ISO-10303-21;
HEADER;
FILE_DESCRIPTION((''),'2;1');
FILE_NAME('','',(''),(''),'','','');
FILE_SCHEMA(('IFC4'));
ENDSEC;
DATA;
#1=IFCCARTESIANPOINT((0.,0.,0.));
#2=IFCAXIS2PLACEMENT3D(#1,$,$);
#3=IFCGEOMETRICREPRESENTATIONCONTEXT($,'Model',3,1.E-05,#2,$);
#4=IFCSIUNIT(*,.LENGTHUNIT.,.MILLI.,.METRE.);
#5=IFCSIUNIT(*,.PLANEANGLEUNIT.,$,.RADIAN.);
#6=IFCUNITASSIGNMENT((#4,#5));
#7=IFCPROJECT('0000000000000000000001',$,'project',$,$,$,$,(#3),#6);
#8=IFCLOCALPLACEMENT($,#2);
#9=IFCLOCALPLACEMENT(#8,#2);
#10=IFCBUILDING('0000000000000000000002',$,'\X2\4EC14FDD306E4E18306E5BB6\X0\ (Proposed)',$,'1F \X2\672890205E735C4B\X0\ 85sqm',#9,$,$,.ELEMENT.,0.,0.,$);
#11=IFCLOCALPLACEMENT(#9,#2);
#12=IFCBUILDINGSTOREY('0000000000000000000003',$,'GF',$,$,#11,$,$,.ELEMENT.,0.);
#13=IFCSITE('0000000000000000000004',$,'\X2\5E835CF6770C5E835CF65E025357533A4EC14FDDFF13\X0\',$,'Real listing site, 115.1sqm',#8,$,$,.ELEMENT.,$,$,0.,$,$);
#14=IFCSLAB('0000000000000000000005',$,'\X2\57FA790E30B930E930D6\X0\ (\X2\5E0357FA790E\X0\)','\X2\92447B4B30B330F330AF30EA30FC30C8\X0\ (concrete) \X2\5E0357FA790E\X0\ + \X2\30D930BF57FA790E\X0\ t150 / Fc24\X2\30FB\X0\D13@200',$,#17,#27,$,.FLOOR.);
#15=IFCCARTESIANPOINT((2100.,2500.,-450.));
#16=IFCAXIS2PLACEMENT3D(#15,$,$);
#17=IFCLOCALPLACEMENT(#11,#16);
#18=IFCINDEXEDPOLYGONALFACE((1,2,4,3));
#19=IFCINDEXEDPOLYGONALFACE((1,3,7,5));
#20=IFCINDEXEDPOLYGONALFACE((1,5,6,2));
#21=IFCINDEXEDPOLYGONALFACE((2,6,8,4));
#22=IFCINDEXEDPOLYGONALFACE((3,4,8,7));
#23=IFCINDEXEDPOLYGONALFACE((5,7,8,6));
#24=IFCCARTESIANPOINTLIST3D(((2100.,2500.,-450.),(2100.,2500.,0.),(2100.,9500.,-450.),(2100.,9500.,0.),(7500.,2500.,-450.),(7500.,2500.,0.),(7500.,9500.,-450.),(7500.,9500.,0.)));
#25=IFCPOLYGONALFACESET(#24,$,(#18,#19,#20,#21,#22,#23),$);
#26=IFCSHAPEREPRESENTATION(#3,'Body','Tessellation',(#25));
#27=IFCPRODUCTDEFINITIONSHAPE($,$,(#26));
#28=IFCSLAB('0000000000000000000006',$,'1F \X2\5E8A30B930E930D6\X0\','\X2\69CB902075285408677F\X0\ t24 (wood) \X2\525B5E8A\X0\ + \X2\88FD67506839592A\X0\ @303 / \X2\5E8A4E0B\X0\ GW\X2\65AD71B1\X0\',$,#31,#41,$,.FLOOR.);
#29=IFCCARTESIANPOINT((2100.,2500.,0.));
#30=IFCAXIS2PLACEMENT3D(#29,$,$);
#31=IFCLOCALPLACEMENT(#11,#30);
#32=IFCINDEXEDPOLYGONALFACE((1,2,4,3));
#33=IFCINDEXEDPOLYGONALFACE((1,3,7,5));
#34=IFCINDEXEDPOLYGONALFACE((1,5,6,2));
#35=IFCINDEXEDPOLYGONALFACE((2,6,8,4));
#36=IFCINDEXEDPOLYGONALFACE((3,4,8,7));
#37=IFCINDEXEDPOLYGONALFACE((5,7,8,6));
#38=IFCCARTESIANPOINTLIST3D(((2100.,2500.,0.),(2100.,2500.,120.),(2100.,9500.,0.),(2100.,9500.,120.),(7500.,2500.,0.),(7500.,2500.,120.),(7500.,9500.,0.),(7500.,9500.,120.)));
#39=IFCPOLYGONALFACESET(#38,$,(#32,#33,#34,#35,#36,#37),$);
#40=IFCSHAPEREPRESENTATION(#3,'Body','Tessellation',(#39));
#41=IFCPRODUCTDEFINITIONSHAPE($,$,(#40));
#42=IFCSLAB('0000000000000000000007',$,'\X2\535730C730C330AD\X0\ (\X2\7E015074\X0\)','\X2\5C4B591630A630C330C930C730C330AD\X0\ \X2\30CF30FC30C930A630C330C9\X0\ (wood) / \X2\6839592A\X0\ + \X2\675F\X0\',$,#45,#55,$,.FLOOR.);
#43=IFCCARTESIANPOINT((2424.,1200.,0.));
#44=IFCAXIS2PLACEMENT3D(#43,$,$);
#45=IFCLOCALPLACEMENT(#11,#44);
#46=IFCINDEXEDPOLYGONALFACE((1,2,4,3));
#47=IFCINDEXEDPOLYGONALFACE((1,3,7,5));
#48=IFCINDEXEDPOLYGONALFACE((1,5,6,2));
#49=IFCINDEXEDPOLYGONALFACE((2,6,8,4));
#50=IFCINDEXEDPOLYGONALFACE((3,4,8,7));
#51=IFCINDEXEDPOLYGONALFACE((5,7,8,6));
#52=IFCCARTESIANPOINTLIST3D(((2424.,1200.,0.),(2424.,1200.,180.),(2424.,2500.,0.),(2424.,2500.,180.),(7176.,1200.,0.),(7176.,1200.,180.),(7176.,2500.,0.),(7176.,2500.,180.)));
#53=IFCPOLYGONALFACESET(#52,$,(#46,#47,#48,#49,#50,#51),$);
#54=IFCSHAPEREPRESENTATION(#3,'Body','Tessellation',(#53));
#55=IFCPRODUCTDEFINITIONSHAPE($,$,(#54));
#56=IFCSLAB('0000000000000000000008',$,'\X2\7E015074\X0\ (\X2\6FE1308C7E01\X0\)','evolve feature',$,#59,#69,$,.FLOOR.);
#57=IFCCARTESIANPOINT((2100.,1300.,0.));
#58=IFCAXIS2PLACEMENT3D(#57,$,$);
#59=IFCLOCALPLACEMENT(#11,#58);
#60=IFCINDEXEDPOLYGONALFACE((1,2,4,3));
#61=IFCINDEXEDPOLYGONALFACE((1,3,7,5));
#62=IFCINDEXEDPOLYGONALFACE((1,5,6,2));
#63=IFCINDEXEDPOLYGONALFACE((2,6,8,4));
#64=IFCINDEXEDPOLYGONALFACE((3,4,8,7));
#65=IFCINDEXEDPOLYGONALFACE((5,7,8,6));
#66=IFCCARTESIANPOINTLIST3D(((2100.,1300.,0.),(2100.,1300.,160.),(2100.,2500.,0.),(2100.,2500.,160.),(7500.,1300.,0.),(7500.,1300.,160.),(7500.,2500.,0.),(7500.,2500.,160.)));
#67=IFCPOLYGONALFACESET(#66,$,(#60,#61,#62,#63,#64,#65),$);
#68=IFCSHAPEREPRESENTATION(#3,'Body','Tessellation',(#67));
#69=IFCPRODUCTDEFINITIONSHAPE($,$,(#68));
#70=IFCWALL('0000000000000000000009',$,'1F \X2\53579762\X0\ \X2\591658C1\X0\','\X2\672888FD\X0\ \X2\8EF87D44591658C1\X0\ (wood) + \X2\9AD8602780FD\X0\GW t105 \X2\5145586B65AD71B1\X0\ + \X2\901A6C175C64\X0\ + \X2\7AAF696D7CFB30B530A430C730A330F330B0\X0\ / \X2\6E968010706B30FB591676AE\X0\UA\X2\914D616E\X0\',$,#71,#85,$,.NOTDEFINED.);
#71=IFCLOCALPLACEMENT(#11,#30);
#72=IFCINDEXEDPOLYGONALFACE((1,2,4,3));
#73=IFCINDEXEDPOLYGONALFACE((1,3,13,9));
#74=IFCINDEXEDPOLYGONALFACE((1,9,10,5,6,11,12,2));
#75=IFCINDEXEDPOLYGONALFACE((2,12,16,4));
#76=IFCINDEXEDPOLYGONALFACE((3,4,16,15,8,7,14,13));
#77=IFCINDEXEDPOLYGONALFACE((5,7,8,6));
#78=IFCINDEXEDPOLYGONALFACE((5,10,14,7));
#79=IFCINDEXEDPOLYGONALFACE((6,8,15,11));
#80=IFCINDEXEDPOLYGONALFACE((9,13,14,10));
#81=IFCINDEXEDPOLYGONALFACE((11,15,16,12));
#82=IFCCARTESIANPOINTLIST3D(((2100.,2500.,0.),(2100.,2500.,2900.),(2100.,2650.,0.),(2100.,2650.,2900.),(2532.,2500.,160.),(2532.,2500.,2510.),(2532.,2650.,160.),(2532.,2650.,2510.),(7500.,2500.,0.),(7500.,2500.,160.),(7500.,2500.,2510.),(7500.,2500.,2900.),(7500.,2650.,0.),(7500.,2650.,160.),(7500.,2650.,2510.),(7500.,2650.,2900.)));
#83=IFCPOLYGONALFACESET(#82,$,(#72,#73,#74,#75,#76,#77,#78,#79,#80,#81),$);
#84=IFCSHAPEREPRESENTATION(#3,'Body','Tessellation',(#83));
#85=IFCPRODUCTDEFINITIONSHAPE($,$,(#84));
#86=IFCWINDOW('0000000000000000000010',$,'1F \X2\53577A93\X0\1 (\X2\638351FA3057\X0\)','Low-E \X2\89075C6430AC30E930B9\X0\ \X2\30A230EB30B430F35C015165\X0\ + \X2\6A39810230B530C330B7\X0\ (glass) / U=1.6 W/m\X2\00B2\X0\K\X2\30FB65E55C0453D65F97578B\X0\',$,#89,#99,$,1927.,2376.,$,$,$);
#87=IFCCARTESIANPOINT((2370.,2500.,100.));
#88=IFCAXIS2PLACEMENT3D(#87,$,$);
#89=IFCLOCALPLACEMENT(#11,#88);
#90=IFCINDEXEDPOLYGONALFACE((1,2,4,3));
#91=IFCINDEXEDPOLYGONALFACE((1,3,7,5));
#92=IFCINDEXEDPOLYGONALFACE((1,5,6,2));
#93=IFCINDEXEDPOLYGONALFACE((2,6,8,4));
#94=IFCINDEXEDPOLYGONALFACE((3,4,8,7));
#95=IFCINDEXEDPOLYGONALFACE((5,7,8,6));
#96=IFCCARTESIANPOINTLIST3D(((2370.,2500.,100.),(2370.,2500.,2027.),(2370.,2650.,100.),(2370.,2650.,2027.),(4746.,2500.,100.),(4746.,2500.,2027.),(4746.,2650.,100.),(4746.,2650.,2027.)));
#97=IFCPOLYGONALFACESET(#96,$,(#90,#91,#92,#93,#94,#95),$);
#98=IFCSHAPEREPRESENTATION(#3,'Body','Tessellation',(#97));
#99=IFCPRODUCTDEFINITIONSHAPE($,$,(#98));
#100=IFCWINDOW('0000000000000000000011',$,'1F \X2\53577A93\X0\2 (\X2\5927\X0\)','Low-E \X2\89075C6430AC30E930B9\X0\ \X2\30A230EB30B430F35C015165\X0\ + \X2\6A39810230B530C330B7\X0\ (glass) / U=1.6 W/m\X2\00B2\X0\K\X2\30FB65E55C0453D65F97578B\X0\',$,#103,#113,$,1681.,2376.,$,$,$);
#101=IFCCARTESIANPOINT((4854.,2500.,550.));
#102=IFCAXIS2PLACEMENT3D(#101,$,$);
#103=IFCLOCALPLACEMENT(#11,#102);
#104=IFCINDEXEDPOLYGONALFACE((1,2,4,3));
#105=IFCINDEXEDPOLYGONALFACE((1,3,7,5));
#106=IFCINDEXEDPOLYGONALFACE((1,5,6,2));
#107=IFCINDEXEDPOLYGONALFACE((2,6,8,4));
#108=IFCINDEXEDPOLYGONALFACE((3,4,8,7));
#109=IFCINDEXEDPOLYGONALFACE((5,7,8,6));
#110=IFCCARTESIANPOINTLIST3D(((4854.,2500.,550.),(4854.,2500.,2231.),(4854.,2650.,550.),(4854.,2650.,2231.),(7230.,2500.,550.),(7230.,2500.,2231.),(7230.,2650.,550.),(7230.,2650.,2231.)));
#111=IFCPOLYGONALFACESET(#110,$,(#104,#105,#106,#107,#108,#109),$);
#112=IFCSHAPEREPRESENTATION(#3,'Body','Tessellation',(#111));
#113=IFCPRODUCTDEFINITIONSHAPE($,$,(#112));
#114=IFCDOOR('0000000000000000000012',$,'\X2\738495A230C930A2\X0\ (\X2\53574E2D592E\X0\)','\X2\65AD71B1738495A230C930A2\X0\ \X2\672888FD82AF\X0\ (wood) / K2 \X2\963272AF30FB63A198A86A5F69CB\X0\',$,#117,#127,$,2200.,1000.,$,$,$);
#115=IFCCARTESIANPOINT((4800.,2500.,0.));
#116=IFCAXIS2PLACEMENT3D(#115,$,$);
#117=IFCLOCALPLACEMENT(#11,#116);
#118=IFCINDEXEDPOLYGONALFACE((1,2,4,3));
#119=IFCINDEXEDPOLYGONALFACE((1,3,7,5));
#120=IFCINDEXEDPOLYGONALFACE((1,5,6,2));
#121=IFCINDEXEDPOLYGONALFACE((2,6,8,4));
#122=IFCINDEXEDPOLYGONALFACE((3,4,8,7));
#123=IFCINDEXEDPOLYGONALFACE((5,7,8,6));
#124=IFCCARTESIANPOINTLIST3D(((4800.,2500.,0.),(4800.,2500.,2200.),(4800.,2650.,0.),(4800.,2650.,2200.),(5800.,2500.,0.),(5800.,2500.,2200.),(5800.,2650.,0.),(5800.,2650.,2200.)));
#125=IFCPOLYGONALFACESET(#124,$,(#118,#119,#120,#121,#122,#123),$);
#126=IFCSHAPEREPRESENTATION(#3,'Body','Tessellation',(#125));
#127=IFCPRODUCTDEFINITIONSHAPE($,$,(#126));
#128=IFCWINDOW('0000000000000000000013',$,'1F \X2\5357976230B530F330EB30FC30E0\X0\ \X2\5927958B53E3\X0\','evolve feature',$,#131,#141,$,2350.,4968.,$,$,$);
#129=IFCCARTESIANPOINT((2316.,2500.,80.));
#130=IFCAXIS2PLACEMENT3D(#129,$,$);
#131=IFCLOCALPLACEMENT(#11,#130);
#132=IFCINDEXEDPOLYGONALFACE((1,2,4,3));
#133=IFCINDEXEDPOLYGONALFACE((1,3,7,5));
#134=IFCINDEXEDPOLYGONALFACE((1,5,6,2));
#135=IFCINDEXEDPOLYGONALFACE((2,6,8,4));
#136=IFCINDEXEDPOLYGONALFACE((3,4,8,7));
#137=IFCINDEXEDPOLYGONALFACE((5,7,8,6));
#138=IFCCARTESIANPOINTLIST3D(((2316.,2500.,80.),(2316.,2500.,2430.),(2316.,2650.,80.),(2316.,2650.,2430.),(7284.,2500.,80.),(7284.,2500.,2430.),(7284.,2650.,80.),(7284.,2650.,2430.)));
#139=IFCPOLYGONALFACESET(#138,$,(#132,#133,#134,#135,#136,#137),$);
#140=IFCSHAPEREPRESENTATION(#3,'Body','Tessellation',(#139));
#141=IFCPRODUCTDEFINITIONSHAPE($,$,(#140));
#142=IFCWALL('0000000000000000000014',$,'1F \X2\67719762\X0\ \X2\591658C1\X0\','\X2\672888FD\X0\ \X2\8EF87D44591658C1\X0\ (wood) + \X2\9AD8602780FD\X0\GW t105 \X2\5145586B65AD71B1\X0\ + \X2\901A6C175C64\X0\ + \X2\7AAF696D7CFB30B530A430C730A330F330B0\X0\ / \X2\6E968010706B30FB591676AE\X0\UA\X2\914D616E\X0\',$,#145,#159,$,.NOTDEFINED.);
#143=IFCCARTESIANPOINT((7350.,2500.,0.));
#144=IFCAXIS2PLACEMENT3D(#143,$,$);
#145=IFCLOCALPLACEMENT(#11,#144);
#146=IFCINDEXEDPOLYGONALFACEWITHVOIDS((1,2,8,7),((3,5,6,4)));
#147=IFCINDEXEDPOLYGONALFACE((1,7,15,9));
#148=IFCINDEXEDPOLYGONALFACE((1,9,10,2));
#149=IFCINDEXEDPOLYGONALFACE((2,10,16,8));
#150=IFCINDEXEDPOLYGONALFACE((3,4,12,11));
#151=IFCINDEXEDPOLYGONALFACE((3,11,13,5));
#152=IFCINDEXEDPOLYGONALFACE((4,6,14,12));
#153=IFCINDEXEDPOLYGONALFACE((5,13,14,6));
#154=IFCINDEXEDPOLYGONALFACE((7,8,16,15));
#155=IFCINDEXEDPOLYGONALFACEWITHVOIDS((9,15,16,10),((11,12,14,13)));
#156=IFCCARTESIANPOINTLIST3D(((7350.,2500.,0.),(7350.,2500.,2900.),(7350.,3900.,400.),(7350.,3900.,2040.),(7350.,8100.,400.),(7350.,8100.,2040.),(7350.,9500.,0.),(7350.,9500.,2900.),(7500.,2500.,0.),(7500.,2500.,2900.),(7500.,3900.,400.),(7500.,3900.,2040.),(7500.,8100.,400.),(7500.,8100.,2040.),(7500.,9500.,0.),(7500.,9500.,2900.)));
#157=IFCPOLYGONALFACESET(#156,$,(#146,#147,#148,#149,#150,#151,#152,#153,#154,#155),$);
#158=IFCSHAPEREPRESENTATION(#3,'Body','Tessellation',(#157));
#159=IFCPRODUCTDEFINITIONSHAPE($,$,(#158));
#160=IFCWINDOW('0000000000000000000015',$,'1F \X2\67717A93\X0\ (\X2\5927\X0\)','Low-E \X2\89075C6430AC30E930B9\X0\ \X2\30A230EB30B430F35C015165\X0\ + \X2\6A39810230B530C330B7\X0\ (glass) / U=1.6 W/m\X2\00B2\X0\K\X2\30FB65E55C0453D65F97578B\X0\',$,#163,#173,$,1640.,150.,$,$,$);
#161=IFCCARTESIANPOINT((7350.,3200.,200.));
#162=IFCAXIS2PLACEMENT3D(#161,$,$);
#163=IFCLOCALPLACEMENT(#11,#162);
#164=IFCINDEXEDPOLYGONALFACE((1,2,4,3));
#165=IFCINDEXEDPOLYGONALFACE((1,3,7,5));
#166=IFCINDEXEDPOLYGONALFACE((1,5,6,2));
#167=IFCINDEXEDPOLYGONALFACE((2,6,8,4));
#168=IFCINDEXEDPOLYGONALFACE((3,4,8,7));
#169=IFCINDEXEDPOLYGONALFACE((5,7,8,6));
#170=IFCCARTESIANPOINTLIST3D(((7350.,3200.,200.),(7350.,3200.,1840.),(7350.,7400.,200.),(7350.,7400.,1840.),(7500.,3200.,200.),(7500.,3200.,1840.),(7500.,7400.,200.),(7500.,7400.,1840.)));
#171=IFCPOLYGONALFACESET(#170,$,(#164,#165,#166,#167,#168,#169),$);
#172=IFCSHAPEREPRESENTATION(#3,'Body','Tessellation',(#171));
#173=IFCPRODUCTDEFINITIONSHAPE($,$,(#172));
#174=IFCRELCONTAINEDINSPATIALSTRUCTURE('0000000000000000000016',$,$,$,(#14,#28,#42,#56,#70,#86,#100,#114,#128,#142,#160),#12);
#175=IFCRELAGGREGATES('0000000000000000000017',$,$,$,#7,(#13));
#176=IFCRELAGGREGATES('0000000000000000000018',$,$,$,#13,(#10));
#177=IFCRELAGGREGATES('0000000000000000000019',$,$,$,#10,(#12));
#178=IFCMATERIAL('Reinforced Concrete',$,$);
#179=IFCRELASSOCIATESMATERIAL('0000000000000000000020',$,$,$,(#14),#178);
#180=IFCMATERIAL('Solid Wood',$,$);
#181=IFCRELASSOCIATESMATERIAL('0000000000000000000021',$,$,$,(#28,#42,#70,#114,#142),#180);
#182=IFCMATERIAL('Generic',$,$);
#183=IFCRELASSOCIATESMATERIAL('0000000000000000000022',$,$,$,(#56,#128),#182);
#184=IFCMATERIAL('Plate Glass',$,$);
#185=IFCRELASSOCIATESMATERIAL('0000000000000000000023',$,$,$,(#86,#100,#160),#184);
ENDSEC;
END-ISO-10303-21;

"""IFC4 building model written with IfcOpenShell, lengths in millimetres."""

from ifc_helpers import new_model, si_unit, frame, frame_2d, origin, place, context, project, spatial, rectangle, extrude, material, element, fill, save


model = new_model("IFC4")

# Units and contexts
model_context = context("Model", 3, precision=1e-05, world=origin())
ifc_project = project(units=[si_unit("LENGTHUNIT", "METRE", prefix="MILLI"), si_unit("PLANEANGLEUNIT", "RADIAN")], contexts=[model_context])

# Site, building, storey
site_placement = place(None, origin())
site = spatial("IfcSite", under=ifc_project, at=site_placement, Name="広島県広島市南区仁保３", ObjectType="Real listing site, 115.1sqm", CompositionType="ELEMENT", RefElevation=0.0)
building_placement = place(site_placement, origin())
building = spatial("IfcBuilding", under=site, at=building_placement, Name="仁保の丘の家 (Proposed)", ObjectType="1F 木造平屋 85sqm", CompositionType="ELEMENT", ElevationOfRefHeight=0.0, ElevationOfTerrain=0.0)
storey_placement = place(building_placement, origin())
storey = spatial("IfcBuildingStorey", under=building, at=storey_placement, Name="GF", CompositionType="ELEMENT", Elevation=0.0)

# Slabs
ifc_material_1 = material(Name="Reinforced Concrete")
slab_1_placement = place(storey_placement, frame((2100.0, 2500.0, -450.0)))
element("IfcSlab", 1, at=slab_1_placement, inside=storey, material=ifc_material_1, Name="基礎スラブ (布基礎)", Description="鉄筋コンクリート (concrete) 布基礎 + ベタ基礎 t150 / Fc24・D13@200", PredefinedType="FLOOR", context=model_context, shape_type="SweptSolid", body=[
    extrude(rectangle(XDim=5400.0, YDim=7000.0, at=frame_2d((2700.0, 3500.0))), frame((2100.0, 2500.0, -450.0)), (0.0, 0.0, 1.0), 450.0),
])
ifc_material_2 = material(Name="Solid Wood")
slab_2_placement = place(storey_placement, frame((2100.0, 2500.0, 0.0)))
element("IfcSlab", 2, at=slab_2_placement, inside=storey, material=ifc_material_2, Name="1F 床スラブ", Description="構造用合板 t24 (wood) 剛床 + 製材根太 @303 / 床下 GW断熱", PredefinedType="FLOOR", context=model_context, shape_type="SweptSolid", body=[
    extrude(rectangle(XDim=5400.0, YDim=7000.0, at=frame_2d((2700.0, 3500.0))), frame((2100.0, 2500.0, 0.0)), (0.0, 0.0, 1.0), 120.0),
])
slab_3_placement = place(storey_placement, frame((2424.0, 1200.0, 0.0)))
element("IfcSlab", 3, at=slab_3_placement, inside=storey, material=ifc_material_2, Name="南デッキ (縁側)", Description="屋外ウッドデッキ ハードウッド (wood) / 根太 + 束", PredefinedType="FLOOR", context=model_context, shape_type="SweptSolid", body=[
    extrude(rectangle(XDim=4752.0, YDim=1300.0, at=frame_2d((2376.0, 650.0))), frame((2424.0, 1200.0, 0.0)), (0.0, 0.0, 1.0), 180.0),
])
ifc_material_3 = material(Name="Generic")
slab_4_placement = place(storey_placement, frame((2100.0, 1300.0, 0.0)))
element("IfcSlab", 4, at=slab_4_placement, inside=storey, material=ifc_material_3, Name="縁側 (濡れ縁)", Description="evolve feature", PredefinedType="FLOOR", context=model_context, shape_type="SweptSolid", body=[
    extrude(rectangle(XDim=5400.0, YDim=1200.0, at=frame_2d((2700.0, 600.0))), frame((2100.0, 1300.0, 0.0)), (0.0, 0.0, 1.0), 160.0),
])

# Wall, openings, windows, door
wall_1_placement = place(storey_placement, frame((2100.0, 2500.0, 0.0)))
wall_1 = element("IfcWall", 5, at=wall_1_placement, inside=storey, material=ifc_material_2, Name="1F 南面 外壁", Description="木製 軸組外壁 (wood) + 高性能GW t105 充填断熱 + 通気層 + 窯業系サイディング / 準耐火・外皮UA配慮", PredefinedType="NOTDEFINED", context=model_context, shape_type="SweptSolid", body=[
    extrude(rectangle(XDim=5400.0, YDim=150.0, at=frame_2d((2700.0, 75.0))), frame((2100.0, 2500.0, 0.0)), (0.0, 0.0, 1.0), 2900.0),
])
opening_1_placement = place(storey_placement, frame((2370.0, 2500.0, 100.0)))
opening_1 = element("IfcOpeningElement", 6, at=opening_1_placement, cuts=wall_1, PredefinedType="NOTDEFINED", context=model_context, shape_type="SweptSolid", body=[
    extrude(rectangle(XDim=2376.0, YDim=150.0, at=frame_2d((1188.0, 75.0))), frame((2370.0, 2500.0, 100.0)), (0.0, 0.0, 1.0), 1927.0),
])
opening_2_placement = place(storey_placement, frame((4854.0, 2500.0, 550.0)))
opening_2 = element("IfcOpeningElement", 7, at=opening_2_placement, cuts=wall_1, PredefinedType="NOTDEFINED", context=model_context, shape_type="SweptSolid", body=[
    extrude(rectangle(XDim=2376.0, YDim=150.0, at=frame_2d((1188.0, 75.0))), frame((4854.0, 2500.0, 550.0)), (0.0, 0.0, 1.0), 1681.0),
])
opening_3_placement = place(storey_placement, frame((4800.0, 2500.0, 0.0)))
opening_3 = element("IfcOpeningElement", 8, at=opening_3_placement, cuts=wall_1, PredefinedType="NOTDEFINED", context=model_context, shape_type="SweptSolid", body=[
    extrude(rectangle(XDim=1000.0, YDim=150.0, at=frame_2d((500.0, 75.0))), frame((4800.0, 2500.0, 0.0)), (0.0, 0.0, 1.0), 2200.0),
])
opening_4_placement = place(storey_placement, frame((2316.0, 2500.0, 80.0)))
opening_4 = element("IfcOpeningElement", 9, at=opening_4_placement, cuts=wall_1, PredefinedType="NOTDEFINED", context=model_context, shape_type="SweptSolid", body=[
    extrude(rectangle(XDim=4968.0, YDim=150.0, at=frame_2d((2484.0, 75.0))), frame((2316.0, 2500.0, 80.0)), (0.0, 0.0, 1.0), 2350.0),
])
ifc_material_4 = material(Name="Plate Glass")
window_1_placement = place(storey_placement, frame((2370.0, 2500.0, 100.0)))
window_1 = element("IfcWindow", 10, at=window_1_placement, inside=storey, material=ifc_material_4, Name="1F 南窓1 (掃出し)", Description="Low-E 複層ガラス アルゴン封入 + 樹脂サッシ (glass) / U=1.6 W/m²K・日射取得型", OverallHeight=1927.0, OverallWidth=2376.0, context=model_context, shape_type="SweptSolid", body=[
    extrude(rectangle(XDim=2376.0, YDim=150.0, at=frame_2d((1188.0, 75.0))), frame((2370.0, 2500.0, 100.0)), (0.0, 0.0, 1.0), 1927.0),
])
fill(opening_1, window_1)
window_2_placement = place(storey_placement, frame((4854.0, 2500.0, 550.0)))
window_2 = element("IfcWindow", 11, at=window_2_placement, inside=storey, material=ifc_material_4, Name="1F 南窓2 (大)", Description="Low-E 複層ガラス アルゴン封入 + 樹脂サッシ (glass) / U=1.6 W/m²K・日射取得型", OverallHeight=1681.0, OverallWidth=2376.0, context=model_context, shape_type="SweptSolid", body=[
    extrude(rectangle(XDim=2376.0, YDim=150.0, at=frame_2d((1188.0, 75.0))), frame((4854.0, 2500.0, 550.0)), (0.0, 0.0, 1.0), 1681.0),
])
fill(opening_2, window_2)
door_placement = place(storey_placement, frame((4800.0, 2500.0, 0.0)))
door = element("IfcDoor", 12, at=door_placement, inside=storey, material=ifc_material_2, Name="玄関ドア (南中央)", Description="断熱玄関ドア 木製芯 (wood) / K2 防犯・採風機構", OverallHeight=2200.0, OverallWidth=1000.0, context=model_context, shape_type="SweptSolid", body=[
    extrude(rectangle(XDim=1000.0, YDim=150.0, at=frame_2d((500.0, 75.0))), frame((4800.0, 2500.0, 0.0)), (0.0, 0.0, 1.0), 2200.0),
])
fill(opening_3, door)
window_3_placement = place(storey_placement, frame((2316.0, 2500.0, 80.0)))
window_3 = element("IfcWindow", 13, at=window_3_placement, inside=storey, material=ifc_material_3, Name="1F 南面サンルーム 大開口", Description="evolve feature", OverallHeight=2350.0, OverallWidth=4968.0, context=model_context, shape_type="SweptSolid", body=[
    extrude(rectangle(XDim=4968.0, YDim=150.0, at=frame_2d((2484.0, 75.0))), frame((2316.0, 2500.0, 80.0)), (0.0, 0.0, 1.0), 2350.0),
])
fill(opening_4, window_3)

# Wall, opening, window
wall_2_placement = place(storey_placement, frame((7350.0, 2500.0, 0.0)))
wall_2 = element("IfcWall", 14, at=wall_2_placement, inside=storey, material=ifc_material_2, Name="1F 東面 外壁", Description="木製 軸組外壁 (wood) + 高性能GW t105 充填断熱 + 通気層 + 窯業系サイディング / 準耐火・外皮UA配慮", PredefinedType="NOTDEFINED", context=model_context, shape_type="SweptSolid", body=[
    extrude(rectangle(XDim=150.0, YDim=7000.0, at=frame_2d((75.0, 3500.0))), frame((7350.0, 2500.0, 0.0)), (0.0, 0.0, 1.0), 2900.0),
])
opening_5_placement = place(storey_placement, frame((7350.0, 3200.0, 200.0)))
opening_5 = element("IfcOpeningElement", 15, at=opening_5_placement, cuts=wall_2, PredefinedType="NOTDEFINED", context=model_context, shape_type="SweptSolid", body=[
    extrude(rectangle(XDim=150.0, YDim=4200.0, at=frame_2d((75.0, 2100.0))), frame((7350.0, 3200.0, 200.0)), (0.0, 0.0, 1.0), 1640.0),
])
window_4_placement = place(storey_placement, frame((7350.0, 3200.0, 200.0)))
window_4 = element("IfcWindow", 16, at=window_4_placement, inside=storey, material=ifc_material_4, Name="1F 東窓 (大)", Description="Low-E 複層ガラス アルゴン封入 + 樹脂サッシ (glass) / U=1.6 W/m²K・日射取得型", OverallHeight=1640.0, OverallWidth=150.0, context=model_context, shape_type="SweptSolid", body=[
    extrude(rectangle(XDim=150.0, YDim=4200.0, at=frame_2d((75.0, 2100.0))), frame((7350.0, 3200.0, 200.0)), (0.0, 0.0, 1.0), 1640.0),
])
fill(opening_5, window_4)

save(model, "model.ifc")
